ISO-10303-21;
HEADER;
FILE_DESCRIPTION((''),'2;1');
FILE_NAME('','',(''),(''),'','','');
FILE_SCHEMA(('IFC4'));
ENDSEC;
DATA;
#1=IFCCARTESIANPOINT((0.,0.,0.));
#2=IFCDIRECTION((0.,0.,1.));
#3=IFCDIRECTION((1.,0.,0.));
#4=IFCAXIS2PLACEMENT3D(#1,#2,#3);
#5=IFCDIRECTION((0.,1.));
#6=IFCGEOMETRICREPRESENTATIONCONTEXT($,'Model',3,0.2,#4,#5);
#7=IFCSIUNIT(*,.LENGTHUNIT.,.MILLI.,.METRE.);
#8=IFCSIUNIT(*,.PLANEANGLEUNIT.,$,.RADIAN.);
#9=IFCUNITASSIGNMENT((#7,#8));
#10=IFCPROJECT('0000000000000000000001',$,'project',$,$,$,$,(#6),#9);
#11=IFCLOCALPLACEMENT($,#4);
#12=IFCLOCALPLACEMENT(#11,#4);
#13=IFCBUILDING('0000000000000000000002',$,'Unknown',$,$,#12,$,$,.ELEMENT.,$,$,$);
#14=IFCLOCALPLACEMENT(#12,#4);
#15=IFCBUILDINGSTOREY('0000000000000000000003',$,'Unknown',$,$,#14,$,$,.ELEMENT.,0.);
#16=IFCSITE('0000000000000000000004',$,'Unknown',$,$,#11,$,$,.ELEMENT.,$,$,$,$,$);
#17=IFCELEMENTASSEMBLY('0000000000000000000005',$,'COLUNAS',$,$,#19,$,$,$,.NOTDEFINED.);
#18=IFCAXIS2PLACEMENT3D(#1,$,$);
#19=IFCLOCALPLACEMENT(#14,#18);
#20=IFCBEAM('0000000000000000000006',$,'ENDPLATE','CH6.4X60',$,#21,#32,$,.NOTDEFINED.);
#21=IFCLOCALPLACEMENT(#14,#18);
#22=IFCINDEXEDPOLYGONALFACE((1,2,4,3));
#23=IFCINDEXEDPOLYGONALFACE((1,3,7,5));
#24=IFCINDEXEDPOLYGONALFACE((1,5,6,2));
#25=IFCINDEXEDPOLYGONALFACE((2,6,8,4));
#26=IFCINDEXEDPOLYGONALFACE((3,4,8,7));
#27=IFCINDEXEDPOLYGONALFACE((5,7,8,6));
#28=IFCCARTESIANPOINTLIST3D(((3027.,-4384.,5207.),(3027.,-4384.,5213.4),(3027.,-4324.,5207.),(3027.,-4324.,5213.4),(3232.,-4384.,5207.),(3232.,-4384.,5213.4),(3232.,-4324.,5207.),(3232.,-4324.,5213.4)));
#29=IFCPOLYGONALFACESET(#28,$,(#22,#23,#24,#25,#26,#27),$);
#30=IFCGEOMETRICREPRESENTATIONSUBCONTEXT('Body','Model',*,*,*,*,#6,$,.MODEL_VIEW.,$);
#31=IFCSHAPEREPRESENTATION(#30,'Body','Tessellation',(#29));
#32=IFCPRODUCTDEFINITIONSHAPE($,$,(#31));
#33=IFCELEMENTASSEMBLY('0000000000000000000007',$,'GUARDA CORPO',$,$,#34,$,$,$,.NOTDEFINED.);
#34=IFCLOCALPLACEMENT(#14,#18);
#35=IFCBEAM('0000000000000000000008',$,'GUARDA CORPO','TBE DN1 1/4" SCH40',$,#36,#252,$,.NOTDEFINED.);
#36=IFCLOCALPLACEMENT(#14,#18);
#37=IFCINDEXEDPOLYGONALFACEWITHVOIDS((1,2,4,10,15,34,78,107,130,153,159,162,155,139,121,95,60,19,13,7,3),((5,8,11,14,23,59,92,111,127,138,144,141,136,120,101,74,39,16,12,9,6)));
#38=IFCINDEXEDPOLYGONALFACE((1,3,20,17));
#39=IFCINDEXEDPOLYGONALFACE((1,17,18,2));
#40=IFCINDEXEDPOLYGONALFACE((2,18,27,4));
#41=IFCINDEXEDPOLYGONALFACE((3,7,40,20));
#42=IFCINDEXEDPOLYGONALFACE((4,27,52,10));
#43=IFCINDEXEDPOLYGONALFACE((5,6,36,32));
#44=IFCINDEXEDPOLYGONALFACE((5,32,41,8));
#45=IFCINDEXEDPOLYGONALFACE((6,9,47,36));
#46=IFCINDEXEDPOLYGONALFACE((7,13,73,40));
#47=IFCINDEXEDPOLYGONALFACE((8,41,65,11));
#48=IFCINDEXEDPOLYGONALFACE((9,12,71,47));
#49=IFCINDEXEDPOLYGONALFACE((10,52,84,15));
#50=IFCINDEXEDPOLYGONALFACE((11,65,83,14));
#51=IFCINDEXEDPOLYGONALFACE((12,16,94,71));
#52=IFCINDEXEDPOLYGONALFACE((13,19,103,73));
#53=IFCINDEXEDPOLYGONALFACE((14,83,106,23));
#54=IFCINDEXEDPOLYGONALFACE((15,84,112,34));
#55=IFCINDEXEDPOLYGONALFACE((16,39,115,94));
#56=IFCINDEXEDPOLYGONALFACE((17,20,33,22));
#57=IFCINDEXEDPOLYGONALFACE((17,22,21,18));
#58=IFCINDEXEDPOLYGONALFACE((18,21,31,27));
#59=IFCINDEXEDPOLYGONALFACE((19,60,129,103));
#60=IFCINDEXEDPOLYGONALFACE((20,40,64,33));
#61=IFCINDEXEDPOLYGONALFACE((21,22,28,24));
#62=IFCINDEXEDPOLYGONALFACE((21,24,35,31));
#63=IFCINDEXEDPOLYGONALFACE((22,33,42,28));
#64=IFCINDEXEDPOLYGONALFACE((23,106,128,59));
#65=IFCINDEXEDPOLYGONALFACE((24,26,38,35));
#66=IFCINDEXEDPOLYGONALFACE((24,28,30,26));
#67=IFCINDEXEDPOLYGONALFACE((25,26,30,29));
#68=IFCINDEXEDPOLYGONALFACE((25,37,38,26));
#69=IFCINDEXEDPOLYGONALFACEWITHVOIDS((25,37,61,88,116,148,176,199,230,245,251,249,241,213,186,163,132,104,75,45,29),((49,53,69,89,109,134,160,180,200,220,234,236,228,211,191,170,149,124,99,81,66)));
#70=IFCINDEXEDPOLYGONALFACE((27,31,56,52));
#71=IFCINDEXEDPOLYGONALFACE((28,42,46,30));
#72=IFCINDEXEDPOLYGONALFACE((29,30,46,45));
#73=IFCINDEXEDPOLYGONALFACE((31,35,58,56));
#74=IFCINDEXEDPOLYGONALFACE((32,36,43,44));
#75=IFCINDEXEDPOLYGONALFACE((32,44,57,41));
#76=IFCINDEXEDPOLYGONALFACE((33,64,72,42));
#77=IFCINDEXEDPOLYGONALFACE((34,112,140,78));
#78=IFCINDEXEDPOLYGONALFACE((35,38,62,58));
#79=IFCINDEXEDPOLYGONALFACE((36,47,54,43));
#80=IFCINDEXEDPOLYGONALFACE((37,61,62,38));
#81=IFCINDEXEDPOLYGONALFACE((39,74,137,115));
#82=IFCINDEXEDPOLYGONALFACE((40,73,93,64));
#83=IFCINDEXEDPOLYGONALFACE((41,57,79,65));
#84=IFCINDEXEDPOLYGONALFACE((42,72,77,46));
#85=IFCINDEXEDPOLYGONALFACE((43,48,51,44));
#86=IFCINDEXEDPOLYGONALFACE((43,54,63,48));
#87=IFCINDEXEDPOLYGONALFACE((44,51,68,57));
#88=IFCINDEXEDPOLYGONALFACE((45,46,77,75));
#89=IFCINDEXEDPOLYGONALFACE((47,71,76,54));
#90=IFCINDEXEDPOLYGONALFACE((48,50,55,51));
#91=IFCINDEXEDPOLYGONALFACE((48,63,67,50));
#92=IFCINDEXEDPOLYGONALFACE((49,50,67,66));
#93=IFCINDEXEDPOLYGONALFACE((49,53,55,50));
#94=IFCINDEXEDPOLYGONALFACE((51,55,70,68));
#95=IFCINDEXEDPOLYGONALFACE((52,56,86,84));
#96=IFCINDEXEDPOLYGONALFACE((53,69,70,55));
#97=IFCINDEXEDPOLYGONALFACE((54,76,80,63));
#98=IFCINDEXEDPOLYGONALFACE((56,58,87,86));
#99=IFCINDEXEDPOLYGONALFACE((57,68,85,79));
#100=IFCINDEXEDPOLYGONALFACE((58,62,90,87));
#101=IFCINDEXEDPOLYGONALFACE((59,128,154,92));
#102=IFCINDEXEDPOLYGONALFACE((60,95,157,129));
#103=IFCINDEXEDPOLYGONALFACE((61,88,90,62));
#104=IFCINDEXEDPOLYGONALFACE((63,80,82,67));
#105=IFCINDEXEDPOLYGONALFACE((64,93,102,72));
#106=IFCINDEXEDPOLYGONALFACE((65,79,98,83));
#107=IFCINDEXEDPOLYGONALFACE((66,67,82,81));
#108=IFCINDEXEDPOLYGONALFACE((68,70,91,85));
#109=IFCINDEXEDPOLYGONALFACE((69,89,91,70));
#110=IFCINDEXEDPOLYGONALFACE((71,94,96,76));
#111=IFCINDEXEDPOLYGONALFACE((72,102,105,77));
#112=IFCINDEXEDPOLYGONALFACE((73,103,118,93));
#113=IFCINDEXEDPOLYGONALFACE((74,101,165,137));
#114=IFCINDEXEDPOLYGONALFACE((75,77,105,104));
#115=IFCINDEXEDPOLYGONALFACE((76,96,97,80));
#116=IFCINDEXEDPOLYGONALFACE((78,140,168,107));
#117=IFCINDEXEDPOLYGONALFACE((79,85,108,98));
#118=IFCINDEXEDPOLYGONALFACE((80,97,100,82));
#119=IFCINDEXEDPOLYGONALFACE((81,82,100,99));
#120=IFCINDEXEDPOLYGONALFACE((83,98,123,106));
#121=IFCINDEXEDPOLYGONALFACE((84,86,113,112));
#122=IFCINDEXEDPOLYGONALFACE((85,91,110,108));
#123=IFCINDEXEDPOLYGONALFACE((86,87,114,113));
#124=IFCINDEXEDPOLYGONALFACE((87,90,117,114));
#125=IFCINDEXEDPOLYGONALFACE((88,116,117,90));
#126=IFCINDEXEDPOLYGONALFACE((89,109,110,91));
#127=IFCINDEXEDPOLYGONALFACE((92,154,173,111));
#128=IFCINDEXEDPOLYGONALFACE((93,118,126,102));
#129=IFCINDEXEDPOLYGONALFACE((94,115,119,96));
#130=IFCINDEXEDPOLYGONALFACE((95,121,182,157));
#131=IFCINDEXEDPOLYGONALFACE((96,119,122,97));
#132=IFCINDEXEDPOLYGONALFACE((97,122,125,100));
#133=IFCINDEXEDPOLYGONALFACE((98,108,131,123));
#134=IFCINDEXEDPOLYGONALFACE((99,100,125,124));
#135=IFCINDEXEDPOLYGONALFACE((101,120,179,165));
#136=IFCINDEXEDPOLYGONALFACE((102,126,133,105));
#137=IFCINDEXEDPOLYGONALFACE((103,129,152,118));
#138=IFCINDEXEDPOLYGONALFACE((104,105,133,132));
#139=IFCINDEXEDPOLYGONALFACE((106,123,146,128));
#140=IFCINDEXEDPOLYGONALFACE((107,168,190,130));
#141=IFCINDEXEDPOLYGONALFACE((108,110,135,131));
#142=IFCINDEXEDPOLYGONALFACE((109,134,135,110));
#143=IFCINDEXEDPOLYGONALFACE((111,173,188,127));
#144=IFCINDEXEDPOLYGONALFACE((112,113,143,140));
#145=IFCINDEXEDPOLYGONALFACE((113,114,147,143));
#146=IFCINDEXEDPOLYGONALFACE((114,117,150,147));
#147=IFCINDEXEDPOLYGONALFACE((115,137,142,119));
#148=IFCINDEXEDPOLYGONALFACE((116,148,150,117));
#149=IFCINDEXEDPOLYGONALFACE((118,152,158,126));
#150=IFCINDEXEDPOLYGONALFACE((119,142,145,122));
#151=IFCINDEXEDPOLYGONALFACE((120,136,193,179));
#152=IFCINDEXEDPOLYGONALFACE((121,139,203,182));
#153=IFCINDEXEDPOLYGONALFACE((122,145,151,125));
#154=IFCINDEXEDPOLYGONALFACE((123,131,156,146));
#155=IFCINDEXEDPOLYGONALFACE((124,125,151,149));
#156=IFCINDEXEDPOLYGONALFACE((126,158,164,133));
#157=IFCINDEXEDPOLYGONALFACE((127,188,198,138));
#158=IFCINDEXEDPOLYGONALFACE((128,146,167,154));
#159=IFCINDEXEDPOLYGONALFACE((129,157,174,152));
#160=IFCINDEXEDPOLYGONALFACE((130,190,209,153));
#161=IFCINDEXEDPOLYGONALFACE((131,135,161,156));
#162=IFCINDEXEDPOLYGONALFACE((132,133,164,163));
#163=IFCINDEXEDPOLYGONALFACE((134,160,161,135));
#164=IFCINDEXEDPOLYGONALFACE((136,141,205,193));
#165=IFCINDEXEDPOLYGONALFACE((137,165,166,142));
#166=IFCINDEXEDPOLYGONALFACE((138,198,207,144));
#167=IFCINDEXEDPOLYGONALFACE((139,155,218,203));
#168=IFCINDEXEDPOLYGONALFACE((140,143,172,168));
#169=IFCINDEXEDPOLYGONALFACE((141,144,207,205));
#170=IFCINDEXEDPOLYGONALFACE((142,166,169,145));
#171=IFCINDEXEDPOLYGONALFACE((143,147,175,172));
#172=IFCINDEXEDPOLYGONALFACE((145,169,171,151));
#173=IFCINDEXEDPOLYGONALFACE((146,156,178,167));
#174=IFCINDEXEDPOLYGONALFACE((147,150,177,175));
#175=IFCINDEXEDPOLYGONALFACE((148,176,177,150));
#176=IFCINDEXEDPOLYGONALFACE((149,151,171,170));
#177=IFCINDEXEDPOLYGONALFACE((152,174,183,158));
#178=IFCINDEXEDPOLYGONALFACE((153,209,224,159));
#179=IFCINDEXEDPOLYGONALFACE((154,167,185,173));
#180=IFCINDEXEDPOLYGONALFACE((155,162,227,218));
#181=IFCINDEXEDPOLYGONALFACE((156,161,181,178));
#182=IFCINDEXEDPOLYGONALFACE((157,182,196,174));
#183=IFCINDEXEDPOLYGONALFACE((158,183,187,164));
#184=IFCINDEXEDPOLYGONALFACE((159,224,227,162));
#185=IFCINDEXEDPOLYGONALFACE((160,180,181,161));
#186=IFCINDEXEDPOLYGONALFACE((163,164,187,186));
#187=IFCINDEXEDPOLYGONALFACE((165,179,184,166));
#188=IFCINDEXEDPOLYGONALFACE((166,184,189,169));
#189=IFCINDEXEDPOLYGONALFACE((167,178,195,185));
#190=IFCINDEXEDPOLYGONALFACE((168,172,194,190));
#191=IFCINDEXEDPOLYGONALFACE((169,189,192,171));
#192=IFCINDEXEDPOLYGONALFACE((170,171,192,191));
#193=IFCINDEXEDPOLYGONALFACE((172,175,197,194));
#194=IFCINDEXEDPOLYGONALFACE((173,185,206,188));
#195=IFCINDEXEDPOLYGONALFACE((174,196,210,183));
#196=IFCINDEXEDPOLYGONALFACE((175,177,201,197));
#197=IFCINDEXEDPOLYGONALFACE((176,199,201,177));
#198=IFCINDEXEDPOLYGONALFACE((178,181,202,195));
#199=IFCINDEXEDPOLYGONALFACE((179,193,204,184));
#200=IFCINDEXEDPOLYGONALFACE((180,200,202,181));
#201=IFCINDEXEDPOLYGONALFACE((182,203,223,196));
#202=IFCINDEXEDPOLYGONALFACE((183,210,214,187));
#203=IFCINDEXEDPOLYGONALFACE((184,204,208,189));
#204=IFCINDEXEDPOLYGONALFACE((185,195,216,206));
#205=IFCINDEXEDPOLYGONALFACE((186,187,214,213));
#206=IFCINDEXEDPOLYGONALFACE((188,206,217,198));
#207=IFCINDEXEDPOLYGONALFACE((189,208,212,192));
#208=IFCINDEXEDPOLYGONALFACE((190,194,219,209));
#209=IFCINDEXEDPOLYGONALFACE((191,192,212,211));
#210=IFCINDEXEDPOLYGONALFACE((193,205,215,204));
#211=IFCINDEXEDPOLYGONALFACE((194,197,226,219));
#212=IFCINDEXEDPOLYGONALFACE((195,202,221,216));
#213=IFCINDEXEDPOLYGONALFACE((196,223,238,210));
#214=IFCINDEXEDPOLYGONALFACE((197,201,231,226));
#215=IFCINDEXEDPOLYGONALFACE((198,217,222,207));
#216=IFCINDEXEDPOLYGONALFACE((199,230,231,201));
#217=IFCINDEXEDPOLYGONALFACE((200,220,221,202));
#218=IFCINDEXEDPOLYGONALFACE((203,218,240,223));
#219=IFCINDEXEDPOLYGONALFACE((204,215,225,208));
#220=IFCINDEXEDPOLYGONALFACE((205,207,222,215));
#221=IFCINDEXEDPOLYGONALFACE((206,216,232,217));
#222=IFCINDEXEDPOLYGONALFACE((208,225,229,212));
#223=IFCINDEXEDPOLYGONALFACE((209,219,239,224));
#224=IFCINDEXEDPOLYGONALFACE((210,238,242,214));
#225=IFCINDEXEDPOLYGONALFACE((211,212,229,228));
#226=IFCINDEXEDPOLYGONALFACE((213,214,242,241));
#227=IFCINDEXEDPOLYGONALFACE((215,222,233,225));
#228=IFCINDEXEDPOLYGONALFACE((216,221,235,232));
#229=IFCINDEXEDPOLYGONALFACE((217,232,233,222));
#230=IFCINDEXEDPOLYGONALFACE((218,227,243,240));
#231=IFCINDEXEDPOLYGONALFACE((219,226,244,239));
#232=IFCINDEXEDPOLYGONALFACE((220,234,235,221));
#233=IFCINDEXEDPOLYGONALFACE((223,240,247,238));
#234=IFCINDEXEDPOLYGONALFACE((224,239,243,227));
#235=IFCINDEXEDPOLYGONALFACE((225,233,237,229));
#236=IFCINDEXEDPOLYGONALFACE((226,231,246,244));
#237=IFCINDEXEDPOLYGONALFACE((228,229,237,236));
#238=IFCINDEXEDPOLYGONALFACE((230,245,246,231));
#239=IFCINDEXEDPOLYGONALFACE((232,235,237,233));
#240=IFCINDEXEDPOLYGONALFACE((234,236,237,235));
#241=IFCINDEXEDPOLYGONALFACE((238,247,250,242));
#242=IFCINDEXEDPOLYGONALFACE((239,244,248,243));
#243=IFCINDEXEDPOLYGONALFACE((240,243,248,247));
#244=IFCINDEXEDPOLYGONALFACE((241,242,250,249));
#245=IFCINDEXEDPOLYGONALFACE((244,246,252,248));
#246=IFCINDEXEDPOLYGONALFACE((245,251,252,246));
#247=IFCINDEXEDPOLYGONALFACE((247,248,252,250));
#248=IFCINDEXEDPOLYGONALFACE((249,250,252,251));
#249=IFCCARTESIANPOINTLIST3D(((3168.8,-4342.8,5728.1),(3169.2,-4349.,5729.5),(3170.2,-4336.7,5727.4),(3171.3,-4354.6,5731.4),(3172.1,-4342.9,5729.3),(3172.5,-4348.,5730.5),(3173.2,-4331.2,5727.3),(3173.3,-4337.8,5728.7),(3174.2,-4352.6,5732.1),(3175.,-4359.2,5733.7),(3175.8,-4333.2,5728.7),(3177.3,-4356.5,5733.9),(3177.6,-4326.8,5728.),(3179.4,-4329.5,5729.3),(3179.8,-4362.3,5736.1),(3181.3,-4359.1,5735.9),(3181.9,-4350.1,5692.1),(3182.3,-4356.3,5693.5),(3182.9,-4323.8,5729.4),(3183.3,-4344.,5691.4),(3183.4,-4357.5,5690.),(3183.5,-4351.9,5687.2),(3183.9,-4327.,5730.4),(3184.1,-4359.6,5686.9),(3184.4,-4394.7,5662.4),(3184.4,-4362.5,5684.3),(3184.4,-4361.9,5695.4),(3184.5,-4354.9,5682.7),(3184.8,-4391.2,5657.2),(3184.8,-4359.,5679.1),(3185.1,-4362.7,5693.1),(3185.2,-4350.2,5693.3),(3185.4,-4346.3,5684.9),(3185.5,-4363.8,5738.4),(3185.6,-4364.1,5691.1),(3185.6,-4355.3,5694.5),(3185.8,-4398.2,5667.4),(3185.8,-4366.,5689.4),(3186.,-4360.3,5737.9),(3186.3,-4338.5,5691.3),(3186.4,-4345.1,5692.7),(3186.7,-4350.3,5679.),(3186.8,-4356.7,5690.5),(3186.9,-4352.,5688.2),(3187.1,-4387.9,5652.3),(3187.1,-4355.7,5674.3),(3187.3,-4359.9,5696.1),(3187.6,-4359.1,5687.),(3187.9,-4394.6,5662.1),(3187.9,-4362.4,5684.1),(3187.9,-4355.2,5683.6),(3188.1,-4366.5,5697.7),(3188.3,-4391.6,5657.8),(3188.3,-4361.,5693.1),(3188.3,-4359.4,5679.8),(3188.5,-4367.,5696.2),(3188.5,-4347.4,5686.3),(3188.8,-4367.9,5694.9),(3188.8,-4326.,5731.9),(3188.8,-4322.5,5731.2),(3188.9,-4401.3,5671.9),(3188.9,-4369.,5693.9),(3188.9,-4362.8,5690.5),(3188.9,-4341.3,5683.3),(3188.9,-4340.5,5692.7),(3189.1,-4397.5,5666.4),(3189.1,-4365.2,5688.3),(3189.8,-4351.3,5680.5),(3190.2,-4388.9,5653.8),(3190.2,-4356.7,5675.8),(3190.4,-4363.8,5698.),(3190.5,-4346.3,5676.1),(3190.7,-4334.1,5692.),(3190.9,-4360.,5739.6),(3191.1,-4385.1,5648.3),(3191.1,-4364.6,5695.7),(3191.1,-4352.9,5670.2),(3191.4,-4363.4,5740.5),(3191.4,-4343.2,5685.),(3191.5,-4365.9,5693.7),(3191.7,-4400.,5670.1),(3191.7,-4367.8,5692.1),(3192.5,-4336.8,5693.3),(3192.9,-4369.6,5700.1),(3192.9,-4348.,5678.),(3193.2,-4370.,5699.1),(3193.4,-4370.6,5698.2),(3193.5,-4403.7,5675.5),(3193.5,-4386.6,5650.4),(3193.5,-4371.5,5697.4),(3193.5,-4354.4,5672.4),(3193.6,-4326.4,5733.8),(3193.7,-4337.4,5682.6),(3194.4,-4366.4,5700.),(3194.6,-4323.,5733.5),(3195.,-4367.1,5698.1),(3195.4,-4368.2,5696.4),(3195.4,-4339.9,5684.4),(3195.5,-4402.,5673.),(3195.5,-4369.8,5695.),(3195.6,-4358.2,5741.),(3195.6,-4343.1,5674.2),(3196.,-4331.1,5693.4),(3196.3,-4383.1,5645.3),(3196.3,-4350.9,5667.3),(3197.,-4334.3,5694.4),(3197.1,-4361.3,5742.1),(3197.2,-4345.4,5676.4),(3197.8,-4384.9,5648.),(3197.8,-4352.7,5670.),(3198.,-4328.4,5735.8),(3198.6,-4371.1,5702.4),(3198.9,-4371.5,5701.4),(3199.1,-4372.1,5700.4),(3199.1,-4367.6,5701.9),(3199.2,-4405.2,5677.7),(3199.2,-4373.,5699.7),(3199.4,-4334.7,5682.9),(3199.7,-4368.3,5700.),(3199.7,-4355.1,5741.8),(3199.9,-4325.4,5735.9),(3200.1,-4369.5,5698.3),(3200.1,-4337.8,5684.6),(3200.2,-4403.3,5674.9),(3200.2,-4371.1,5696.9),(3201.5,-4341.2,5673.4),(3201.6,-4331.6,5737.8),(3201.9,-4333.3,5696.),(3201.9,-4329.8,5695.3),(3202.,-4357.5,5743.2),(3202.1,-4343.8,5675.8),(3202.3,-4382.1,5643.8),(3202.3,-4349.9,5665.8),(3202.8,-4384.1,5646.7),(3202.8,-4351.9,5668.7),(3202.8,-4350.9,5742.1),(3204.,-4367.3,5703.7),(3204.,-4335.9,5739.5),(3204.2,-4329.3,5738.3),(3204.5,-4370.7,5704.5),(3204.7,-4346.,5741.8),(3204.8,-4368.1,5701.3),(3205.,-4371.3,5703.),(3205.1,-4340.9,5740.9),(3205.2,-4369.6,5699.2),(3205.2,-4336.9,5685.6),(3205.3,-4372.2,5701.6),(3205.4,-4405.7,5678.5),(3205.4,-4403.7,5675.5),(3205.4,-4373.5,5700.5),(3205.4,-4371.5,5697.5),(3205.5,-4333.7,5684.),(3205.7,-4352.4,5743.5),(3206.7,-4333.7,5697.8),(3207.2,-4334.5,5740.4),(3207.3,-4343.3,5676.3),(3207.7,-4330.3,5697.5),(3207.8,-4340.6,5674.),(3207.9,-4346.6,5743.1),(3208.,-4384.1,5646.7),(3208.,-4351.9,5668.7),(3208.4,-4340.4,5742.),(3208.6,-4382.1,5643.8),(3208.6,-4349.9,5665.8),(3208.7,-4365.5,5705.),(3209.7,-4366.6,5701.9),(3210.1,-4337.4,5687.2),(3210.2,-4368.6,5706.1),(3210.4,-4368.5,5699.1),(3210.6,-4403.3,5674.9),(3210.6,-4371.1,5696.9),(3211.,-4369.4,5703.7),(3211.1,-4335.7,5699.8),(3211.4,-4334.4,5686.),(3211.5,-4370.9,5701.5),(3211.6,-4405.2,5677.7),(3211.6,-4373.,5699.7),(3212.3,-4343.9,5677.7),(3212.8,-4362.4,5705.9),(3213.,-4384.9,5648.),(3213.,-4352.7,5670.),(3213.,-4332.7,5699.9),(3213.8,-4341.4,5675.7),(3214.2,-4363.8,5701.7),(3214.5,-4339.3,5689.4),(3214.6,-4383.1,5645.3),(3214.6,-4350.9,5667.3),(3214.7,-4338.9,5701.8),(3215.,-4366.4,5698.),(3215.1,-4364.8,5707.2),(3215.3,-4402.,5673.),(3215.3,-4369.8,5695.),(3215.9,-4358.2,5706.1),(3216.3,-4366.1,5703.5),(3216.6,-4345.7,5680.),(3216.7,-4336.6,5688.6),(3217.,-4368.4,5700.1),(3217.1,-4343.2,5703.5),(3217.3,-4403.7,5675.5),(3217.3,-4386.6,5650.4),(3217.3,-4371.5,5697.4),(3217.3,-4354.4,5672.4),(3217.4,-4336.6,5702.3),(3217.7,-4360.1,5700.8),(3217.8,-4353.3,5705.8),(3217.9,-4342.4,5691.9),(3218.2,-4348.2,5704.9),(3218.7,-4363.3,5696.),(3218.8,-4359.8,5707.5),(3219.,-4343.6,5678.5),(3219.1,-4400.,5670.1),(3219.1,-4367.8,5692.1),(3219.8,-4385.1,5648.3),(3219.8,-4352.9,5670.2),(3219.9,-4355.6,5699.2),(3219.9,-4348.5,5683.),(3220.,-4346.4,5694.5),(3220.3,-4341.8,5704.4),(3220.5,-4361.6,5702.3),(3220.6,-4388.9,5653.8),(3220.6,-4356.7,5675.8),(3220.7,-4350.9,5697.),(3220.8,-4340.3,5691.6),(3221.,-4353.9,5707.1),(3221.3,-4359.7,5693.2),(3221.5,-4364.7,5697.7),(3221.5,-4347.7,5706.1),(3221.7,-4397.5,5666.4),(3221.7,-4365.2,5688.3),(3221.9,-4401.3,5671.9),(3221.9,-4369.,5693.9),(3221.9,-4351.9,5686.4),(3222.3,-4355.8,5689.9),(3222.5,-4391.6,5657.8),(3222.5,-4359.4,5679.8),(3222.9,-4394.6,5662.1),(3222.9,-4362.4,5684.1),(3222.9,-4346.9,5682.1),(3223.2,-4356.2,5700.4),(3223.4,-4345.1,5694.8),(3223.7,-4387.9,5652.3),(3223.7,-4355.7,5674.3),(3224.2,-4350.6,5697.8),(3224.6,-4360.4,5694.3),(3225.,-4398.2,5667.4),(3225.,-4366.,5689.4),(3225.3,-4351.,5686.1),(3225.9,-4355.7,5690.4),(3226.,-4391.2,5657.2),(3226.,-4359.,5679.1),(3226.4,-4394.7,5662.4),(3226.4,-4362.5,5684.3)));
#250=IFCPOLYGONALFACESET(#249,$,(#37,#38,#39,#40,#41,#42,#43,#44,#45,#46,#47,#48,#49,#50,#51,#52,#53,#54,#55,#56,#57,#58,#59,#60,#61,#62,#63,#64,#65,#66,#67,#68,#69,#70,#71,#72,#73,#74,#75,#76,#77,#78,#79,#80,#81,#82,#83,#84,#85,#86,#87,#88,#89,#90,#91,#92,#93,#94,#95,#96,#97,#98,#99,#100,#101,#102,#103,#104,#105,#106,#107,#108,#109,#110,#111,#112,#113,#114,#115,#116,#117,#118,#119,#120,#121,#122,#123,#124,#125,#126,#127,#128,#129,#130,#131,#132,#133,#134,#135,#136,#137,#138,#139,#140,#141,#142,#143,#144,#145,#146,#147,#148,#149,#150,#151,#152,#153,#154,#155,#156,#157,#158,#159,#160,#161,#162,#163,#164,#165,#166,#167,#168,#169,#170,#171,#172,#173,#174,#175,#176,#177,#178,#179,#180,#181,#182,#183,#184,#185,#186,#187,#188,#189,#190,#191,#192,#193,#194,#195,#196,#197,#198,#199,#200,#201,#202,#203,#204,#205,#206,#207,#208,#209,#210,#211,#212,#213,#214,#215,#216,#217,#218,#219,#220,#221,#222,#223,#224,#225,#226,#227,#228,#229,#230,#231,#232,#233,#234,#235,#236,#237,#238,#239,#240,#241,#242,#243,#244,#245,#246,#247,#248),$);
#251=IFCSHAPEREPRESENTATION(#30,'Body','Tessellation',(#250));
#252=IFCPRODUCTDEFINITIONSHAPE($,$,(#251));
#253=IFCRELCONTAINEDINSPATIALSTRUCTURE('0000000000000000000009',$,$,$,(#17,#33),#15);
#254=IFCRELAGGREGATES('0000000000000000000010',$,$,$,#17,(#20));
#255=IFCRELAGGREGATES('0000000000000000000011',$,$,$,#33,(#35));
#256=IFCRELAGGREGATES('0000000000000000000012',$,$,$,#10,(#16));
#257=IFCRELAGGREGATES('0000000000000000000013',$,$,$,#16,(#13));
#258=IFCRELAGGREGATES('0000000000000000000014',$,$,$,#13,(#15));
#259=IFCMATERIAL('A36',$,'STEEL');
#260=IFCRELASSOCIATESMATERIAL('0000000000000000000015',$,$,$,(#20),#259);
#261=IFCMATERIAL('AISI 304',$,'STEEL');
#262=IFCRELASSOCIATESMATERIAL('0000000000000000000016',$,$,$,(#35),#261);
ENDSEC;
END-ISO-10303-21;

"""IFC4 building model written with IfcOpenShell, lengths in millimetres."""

from ifc_helpers import new_model, entity, si_unit, direction, frame, origin_with_axes, place, context, subcontext, project, spatial, line, indexed_curve, outline, extrude, material, element, aggregate, save


model = new_model("IFC4")

# Units and contexts
model_context = context("Model", 3, precision=0.2, world=origin_with_axes(), true_north=direction((0.0, 1.0)))
body_context = subcontext(model_context, "Body", "Model", "MODEL_VIEW")
ifc_project = project(units=[si_unit("LENGTHUNIT", "METRE", prefix="MILLI"), si_unit("PLANEANGLEUNIT", "RADIAN")], contexts=[model_context])

# Site, building, storey
site_placement = place(None, origin_with_axes())
site = spatial("IfcSite", under=ifc_project, at=site_placement, Name="Unknown", CompositionType="ELEMENT")
building_placement = place(site_placement, origin_with_axes())
building = spatial("IfcBuilding", under=site, at=building_placement, Name="Unknown", CompositionType="ELEMENT")
storey_placement = place(building_placement, origin_with_axes())
storey = spatial("IfcBuildingStorey", under=building, at=storey_placement, Name="Unknown", CompositionType="ELEMENT", Elevation=0.0)

# Shared definitions
ifc_material_1 = material(Name="A36", Category="STEEL")

# Element assembly, beam
assembly_1_placement = place(storey_placement, frame((3129.5, -4354.0, 5210.0), z_axis=(0.0, -1.0, 0.0), x_axis=(0.0, 0.0, 1.0)))
assembly_1 = element("IfcElementAssembly", 1, at=assembly_1_placement, inside=storey, Name="COLUNAS", PredefinedType="NOTDEFINED")
beam_1_placement = place(assembly_1_placement, frame((0.1, -102.5, 0.0), z_axis=(1.0, 0.0, 0.0), x_axis=(0.0, 1.0, 0.0)))
beam_1 = element("IfcBeam", 2, at=beam_1_placement, material=ifc_material_1, Name="ENDPLATE", Description="CH6.4X60", PredefinedType="NOTDEFINED", context=body_context, shape_type="SolidModel", body=[
    extrude(outline(indexed_curve([(-3.2, -30.0), (3.2, -30.0), (3.2, 30.0), (-3.2, 30.0)], segments=[line(1, 2, 3, 4, 1)])), frame((0.0, 0.0, 0.0), z_axis=(-1.0, 0.0, 0.0), x_axis=(0.0, 0.0, 1.0)), (0.0, 0.0, -1.0), 205.0),
])

# Element assembly, beam
assembly_2_placement = place(storey_placement, frame((2908.2, -5645.6, 3955.0), z_axis=(0.000512, -1.0, -0.000003), x_axis=(0.000003, -0.000003, 1.0)))
assembly_2 = element("IfcElementAssembly", 3, at=assembly_2_placement, inside=storey, Name="GUARDA CORPO", PredefinedType="NOTDEFINED")
ifc_material_2 = material(Name="AISI 304", Category="STEEL")
beam_2_placement = place(assembly_2_placement, frame((1706.1, -297.9, -1251.6), z_axis=(0.826215, 0.000295, 0.563355), x_axis=(0.563355, -0.000419, -0.826215)))
beam_2 = element("IfcBeam", 4, at=beam_2_placement, material=ifc_material_2, Name="GUARDA CORPO", Description="TBE DN1 1/4\" SCH40", PredefinedType="NOTDEFINED", context=body_context, shape_type="SolidModel", body=[
    entity("IfcSweptDiskSolid", entity("IfcIndexedPolyCurve", entity("IfcCartesianPointList3D", [[0.0, 0.0, 0.0], [39.0, 0.0, 0.0], [49.1, 1.0, 1.9], [57.4, 3.7, 7.2], [83.7, 16.8, 32.9]]), [entity("IfcLineIndex", [1, 2]), entity("IfcArcIndex", [2, 3, 4]), entity("IfcLineIndex", [4, 5])]), 21.1, 17.5),
])

aggregate(assembly_1, [beam_1])

aggregate(assembly_2, [beam_2])

save(model, "model.ifc")
